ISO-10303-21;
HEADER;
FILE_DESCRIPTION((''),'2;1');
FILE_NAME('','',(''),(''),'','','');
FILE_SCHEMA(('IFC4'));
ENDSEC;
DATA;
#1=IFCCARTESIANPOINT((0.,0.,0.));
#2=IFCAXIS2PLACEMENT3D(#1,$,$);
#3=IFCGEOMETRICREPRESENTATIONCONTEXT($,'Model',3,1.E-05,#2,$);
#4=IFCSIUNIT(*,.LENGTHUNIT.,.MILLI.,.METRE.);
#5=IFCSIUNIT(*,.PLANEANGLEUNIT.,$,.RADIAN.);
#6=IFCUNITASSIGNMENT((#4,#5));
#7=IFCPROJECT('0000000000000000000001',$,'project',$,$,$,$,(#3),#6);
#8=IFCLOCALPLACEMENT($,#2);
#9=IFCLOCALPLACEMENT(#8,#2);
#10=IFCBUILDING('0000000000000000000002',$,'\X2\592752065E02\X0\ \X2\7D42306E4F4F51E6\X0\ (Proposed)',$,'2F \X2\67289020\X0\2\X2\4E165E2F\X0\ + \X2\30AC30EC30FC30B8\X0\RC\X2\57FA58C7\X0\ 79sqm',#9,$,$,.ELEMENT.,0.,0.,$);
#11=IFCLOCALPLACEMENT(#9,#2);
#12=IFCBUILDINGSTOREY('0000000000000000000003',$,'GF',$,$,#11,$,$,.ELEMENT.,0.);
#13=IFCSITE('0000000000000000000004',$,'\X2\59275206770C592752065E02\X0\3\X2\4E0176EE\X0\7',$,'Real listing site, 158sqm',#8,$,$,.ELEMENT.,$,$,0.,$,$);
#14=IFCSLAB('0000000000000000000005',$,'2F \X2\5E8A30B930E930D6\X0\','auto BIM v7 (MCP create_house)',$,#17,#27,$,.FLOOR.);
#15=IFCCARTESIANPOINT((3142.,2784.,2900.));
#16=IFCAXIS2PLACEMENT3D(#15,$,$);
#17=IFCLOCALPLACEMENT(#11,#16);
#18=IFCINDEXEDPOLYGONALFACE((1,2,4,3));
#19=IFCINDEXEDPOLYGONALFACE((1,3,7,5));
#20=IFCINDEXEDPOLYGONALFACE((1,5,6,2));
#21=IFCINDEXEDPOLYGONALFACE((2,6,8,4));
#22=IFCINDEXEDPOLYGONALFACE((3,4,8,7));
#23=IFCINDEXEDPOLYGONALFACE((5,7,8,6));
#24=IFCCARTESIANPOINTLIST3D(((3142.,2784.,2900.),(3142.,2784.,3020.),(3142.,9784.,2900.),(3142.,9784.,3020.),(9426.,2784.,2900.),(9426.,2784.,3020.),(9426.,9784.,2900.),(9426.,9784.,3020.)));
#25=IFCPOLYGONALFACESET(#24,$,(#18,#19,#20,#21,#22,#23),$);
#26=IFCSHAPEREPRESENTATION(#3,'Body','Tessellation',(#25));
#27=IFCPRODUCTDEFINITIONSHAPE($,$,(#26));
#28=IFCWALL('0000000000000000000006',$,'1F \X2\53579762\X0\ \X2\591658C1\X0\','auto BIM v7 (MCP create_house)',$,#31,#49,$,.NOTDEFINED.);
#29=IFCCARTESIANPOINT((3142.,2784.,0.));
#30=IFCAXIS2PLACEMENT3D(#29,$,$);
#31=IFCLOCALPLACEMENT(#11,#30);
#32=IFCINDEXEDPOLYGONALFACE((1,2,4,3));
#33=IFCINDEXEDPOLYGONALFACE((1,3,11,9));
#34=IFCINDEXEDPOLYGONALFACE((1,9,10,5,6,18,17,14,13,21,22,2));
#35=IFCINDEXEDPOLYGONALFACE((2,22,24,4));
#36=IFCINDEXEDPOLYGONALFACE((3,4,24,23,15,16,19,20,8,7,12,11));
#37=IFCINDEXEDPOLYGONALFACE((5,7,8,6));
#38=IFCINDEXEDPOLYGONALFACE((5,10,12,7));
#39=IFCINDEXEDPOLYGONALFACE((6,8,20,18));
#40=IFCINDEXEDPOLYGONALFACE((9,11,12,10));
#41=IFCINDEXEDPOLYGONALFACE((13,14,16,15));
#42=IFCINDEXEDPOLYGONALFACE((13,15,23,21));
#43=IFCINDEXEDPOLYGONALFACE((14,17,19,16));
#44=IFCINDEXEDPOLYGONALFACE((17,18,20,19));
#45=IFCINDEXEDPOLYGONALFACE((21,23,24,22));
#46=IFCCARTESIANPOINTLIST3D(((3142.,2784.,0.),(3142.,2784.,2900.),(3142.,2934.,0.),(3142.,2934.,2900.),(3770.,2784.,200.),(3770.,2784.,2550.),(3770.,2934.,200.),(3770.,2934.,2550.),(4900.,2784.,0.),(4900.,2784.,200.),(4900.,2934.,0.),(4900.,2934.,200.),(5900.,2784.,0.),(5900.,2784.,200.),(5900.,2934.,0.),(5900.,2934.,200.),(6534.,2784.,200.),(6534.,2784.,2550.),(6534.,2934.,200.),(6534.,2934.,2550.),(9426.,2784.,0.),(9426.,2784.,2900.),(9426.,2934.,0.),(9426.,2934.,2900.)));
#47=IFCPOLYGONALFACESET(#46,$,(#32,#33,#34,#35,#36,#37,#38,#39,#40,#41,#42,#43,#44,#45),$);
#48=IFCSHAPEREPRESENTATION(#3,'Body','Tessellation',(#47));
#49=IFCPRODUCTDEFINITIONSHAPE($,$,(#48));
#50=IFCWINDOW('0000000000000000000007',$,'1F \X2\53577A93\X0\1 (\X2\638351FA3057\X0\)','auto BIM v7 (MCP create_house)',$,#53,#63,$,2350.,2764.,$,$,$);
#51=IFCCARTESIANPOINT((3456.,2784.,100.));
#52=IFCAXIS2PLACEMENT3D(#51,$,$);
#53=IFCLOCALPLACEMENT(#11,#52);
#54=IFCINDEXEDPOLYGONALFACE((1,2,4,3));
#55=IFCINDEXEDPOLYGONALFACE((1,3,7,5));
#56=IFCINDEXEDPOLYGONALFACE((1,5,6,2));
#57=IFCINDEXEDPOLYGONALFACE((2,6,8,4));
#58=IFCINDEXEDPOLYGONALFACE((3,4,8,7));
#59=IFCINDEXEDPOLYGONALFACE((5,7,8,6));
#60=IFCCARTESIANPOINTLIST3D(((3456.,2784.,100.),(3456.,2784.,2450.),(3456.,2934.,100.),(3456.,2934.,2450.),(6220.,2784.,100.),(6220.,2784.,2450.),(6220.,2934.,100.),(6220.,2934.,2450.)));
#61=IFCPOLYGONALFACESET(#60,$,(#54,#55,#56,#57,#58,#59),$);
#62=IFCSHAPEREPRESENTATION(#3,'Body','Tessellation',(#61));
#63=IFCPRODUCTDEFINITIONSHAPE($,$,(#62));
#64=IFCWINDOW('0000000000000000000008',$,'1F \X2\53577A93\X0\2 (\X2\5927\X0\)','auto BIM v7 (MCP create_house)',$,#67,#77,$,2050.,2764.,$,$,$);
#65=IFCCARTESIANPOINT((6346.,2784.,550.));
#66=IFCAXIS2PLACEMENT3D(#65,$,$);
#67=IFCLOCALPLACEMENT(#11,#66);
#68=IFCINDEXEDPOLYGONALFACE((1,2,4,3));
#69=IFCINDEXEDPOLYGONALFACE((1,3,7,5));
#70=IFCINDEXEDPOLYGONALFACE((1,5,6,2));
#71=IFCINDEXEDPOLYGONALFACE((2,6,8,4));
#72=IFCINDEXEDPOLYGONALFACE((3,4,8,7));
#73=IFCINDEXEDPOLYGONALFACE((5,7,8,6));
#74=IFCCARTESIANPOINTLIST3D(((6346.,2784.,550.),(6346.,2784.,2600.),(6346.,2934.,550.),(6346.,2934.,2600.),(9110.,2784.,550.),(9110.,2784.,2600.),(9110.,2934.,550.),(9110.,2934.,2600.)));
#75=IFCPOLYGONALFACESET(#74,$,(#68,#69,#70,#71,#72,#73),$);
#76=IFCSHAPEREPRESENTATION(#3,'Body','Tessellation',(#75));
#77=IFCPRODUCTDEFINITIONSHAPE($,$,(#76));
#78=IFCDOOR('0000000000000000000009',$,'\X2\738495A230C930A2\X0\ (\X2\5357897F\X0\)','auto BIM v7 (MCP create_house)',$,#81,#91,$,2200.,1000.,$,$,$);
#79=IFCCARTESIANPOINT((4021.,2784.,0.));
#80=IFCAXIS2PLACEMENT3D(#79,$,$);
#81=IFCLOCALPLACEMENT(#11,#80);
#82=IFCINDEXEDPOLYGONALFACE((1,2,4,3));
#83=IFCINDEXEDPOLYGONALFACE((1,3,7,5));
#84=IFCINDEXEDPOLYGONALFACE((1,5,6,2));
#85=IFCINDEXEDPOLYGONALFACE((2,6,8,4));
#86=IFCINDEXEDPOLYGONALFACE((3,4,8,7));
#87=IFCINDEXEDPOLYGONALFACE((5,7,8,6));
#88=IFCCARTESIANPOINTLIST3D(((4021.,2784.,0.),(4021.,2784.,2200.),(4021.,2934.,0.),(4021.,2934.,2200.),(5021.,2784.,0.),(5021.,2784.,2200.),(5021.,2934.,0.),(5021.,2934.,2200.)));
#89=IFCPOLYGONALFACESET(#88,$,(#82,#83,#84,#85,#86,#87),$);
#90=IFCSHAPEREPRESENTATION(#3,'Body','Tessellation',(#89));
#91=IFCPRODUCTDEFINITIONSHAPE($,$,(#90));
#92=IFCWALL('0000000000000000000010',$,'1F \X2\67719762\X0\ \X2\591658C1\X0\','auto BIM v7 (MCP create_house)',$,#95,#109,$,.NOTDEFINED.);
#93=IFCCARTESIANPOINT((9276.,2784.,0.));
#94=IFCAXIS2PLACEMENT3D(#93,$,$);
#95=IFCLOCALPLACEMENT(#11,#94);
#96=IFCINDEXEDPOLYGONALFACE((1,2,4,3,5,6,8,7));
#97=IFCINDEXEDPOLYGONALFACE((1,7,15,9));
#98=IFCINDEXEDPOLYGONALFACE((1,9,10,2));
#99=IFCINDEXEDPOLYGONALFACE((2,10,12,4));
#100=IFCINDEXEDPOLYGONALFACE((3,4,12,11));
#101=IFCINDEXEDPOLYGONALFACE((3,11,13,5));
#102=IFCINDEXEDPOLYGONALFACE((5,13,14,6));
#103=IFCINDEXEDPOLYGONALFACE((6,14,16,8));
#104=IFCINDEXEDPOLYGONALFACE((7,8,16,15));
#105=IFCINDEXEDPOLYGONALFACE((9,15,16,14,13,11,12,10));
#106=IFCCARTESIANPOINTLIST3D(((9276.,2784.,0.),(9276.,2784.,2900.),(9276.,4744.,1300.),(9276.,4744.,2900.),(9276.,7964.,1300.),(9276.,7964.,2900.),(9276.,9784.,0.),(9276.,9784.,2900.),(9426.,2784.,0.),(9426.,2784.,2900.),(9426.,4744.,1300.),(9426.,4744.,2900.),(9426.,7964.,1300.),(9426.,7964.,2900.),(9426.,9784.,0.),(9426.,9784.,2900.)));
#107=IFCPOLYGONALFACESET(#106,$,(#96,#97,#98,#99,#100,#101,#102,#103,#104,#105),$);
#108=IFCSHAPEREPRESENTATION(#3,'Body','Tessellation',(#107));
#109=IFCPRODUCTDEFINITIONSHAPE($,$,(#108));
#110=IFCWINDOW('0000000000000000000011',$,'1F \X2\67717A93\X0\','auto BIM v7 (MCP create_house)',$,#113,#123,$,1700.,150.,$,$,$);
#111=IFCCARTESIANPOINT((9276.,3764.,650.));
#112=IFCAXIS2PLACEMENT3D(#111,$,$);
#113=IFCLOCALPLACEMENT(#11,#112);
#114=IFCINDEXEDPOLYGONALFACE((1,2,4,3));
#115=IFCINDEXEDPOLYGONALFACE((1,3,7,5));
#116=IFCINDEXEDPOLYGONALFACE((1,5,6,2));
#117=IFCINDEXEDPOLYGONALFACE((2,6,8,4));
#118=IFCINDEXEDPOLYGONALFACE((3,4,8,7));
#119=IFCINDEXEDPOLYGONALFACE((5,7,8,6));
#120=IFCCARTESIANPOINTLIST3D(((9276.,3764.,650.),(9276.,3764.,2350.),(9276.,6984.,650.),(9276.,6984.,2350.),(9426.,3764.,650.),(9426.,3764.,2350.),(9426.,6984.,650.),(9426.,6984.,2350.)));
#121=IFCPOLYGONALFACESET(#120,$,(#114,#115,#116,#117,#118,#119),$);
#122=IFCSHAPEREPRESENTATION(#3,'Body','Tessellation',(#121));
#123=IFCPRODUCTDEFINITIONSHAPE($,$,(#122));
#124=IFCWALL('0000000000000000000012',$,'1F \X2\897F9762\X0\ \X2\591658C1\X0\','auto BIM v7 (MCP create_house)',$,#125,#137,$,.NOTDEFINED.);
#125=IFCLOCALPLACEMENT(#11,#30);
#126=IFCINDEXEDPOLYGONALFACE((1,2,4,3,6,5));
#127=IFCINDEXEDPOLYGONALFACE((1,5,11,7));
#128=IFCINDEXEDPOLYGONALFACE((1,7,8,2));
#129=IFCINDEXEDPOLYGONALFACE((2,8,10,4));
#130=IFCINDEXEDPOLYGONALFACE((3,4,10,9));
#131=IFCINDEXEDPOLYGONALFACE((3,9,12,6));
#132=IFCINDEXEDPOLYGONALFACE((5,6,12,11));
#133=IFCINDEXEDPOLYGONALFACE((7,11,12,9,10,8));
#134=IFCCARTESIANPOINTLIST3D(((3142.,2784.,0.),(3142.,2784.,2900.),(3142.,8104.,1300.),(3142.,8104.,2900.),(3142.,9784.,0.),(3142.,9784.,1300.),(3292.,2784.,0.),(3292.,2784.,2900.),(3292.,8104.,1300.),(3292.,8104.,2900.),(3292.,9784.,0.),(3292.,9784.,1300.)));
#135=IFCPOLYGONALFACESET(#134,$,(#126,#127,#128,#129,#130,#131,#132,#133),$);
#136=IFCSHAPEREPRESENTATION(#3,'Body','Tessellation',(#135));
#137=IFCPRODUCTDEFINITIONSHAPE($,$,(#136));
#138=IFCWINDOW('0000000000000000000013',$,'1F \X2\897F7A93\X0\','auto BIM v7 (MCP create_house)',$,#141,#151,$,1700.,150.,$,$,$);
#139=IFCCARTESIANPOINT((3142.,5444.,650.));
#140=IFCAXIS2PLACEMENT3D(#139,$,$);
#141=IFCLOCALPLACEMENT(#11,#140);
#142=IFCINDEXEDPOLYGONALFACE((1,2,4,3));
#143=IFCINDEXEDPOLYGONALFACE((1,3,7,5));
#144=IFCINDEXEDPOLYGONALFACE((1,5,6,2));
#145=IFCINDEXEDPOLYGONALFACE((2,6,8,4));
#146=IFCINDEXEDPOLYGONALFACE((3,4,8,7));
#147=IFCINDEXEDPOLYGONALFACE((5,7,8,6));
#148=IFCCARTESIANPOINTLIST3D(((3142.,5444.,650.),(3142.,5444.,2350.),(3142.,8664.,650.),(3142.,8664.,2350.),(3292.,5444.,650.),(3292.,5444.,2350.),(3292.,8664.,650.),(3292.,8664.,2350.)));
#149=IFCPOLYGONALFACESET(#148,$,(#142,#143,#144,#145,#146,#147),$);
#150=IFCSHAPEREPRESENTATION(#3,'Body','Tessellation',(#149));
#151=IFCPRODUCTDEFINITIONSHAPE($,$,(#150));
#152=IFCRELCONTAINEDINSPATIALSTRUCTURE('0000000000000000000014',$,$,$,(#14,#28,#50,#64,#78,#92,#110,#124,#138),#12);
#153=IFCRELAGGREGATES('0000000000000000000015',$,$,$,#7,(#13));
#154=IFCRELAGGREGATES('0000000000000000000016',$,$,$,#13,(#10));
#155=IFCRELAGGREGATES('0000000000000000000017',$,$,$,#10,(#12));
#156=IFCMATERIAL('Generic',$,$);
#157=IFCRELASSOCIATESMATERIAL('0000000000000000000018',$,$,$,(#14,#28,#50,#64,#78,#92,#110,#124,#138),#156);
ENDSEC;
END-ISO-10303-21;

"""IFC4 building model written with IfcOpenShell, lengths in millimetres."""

from ifc_helpers import new_model, si_unit, frame, frame_2d, origin, place, context, project, spatial, rectangle, extrude, material, element, fill, save


model = new_model("IFC4")

# Units and contexts
model_context = context("Model", 3, precision=1e-05, world=origin())
ifc_project = project(units=[si_unit("LENGTHUNIT", "METRE", prefix="MILLI"), si_unit("PLANEANGLEUNIT", "RADIAN")], contexts=[model_context])

# Site, building, storey
site_placement = place(None, origin())
site = spatial("IfcSite", under=ifc_project, at=site_placement, Name="大分県大分市3丁目7", ObjectType="Real listing site, 158sqm", CompositionType="ELEMENT", RefElevation=0.0)
building_placement = place(site_placement, origin())
building = spatial("IfcBuilding", under=site, at=building_placement, Name="大分市 終の住処 (Proposed)", ObjectType="2F 木造2世帯 + ガレージRC基壇 79sqm", CompositionType="ELEMENT", ElevationOfRefHeight=0.0, ElevationOfTerrain=0.0)
storey_placement = place(building_placement, origin())
storey = spatial("IfcBuildingStorey", under=building, at=storey_placement, Name="GF", CompositionType="ELEMENT", Elevation=0.0)

# Slab
ifc_material = material(Name="Generic")
slab_1_placement = place(storey_placement, frame((3142.0, 2784.0, 2900.0)))
element("IfcSlab", 1, at=slab_1_placement, inside=storey, material=ifc_material, Name="2F 床スラブ", Description="auto BIM v7 (MCP create_house)", PredefinedType="FLOOR", context=model_context, shape_type="SweptSolid", body=[
    extrude(rectangle(XDim=6284.0, YDim=7000.0, at=frame_2d((3142.0, 3500.0))), frame((3142.0, 2784.0, 2900.0)), (0.0, 0.0, 1.0), 120.0),
])

# Wall, openings, windows, door
wall_1_placement = place(storey_placement, frame((3142.0, 2784.0, 0.0)))
wall_1 = element("IfcWall", 2, at=wall_1_placement, inside=storey, material=ifc_material, Name="1F 南面 外壁", Description="auto BIM v7 (MCP create_house)", PredefinedType="NOTDEFINED", context=model_context, shape_type="SweptSolid", body=[
    extrude(rectangle(XDim=6284.0, YDim=150.0, at=frame_2d((3142.0, 75.0))), frame((3142.0, 2784.0, 0.0)), (0.0, 0.0, 1.0), 2900.0),
])
opening_1_placement = place(storey_placement, frame((3456.0, 2784.0, 100.0)))
opening_1 = element("IfcOpeningElement", 3, at=opening_1_placement, cuts=wall_1, PredefinedType="NOTDEFINED", context=model_context, shape_type="SweptSolid", body=[
    extrude(rectangle(XDim=2764.0, YDim=150.0, at=frame_2d((1382.0, 75.0))), frame((3456.0, 2784.0, 100.0)), (0.0, 0.0, 1.0), 2350.0),
])
opening_2_placement = place(storey_placement, frame((6346.0, 2784.0, 550.0)))
opening_2 = element("IfcOpeningElement", 4, at=opening_2_placement, cuts=wall_1, PredefinedType="NOTDEFINED", context=model_context, shape_type="SweptSolid", body=[
    extrude(rectangle(XDim=2764.0, YDim=150.0, at=frame_2d((1382.0, 75.0))), frame((6346.0, 2784.0, 550.0)), (0.0, 0.0, 1.0), 2050.0),
])
opening_3_placement = place(storey_placement, frame((4021.0, 2784.0, 0.0)))
opening_3 = element("IfcOpeningElement", 5, at=opening_3_placement, cuts=wall_1, PredefinedType="NOTDEFINED", context=model_context, shape_type="SweptSolid", body=[
    extrude(rectangle(XDim=1000.0, YDim=150.0, at=frame_2d((500.0, 75.0))), frame((4021.0, 2784.0, 0.0)), (0.0, 0.0, 1.0), 2200.0),
])
window_1_placement = place(storey_placement, frame((3456.0, 2784.0, 100.0)))
window_1 = element("IfcWindow", 6, at=window_1_placement, inside=storey, material=ifc_material, Name="1F 南窓1 (掃出し)", Description="auto BIM v7 (MCP create_house)", OverallHeight=2350.0, OverallWidth=2764.0, context=model_context, shape_type="SweptSolid", body=[
    extrude(rectangle(XDim=2764.0, YDim=150.0, at=frame_2d((1382.0, 75.0))), frame((3456.0, 2784.0, 100.0)), (0.0, 0.0, 1.0), 2350.0),
])
fill(opening_1, window_1)
window_2_placement = place(storey_placement, frame((6346.0, 2784.0, 550.0)))
window_2 = element("IfcWindow", 7, at=window_2_placement, inside=storey, material=ifc_material, Name="1F 南窓2 (大)", Description="auto BIM v7 (MCP create_house)", OverallHeight=2050.0, OverallWidth=2764.0, context=model_context, shape_type="SweptSolid", body=[
    extrude(rectangle(XDim=2764.0, YDim=150.0, at=frame_2d((1382.0, 75.0))), frame((6346.0, 2784.0, 550.0)), (0.0, 0.0, 1.0), 2050.0),
])
fill(opening_2, window_2)
door_placement = place(storey_placement, frame((4021.0, 2784.0, 0.0)))
door = element("IfcDoor", 8, at=door_placement, inside=storey, material=ifc_material, Name="玄関ドア (南西)", Description="auto BIM v7 (MCP create_house)", OverallHeight=2200.0, OverallWidth=1000.0, context=model_context, shape_type="SweptSolid", body=[
    extrude(rectangle(XDim=1000.0, YDim=150.0, at=frame_2d((500.0, 75.0))), frame((4021.0, 2784.0, 0.0)), (0.0, 0.0, 1.0), 2200.0),
])
fill(opening_3, door)

# Walls, openings, windows
wall_2_placement = place(storey_placement, frame((9276.0, 2784.0, 0.0)))
wall_2 = element("IfcWall", 9, at=wall_2_placement, inside=storey, material=ifc_material, Name="1F 東面 外壁", Description="auto BIM v7 (MCP create_house)", PredefinedType="NOTDEFINED", context=model_context, shape_type="SweptSolid", body=[
    extrude(rectangle(XDim=150.0, YDim=7000.0, at=frame_2d((75.0, 3500.0))), frame((9276.0, 2784.0, 0.0)), (0.0, 0.0, 1.0), 2900.0),
])
opening_4_placement = place(storey_placement, frame((9276.0, 3764.0, 650.0)))
opening_4 = element("IfcOpeningElement", 10, at=opening_4_placement, cuts=wall_2, PredefinedType="NOTDEFINED", context=model_context, shape_type="SweptSolid", body=[
    extrude(rectangle(XDim=150.0, YDim=3220.0, at=frame_2d((75.0, 1610.0))), frame((9276.0, 3764.0, 650.0)), (0.0, 0.0, 1.0), 1700.0),
])
window_3_placement = place(storey_placement, frame((9276.0, 3764.0, 650.0)))
window_3 = element("IfcWindow", 11, at=window_3_placement, inside=storey, material=ifc_material, Name="1F 東窓", Description="auto BIM v7 (MCP create_house)", OverallHeight=1700.0, OverallWidth=150.0, context=model_context, shape_type="SweptSolid", body=[
    extrude(rectangle(XDim=150.0, YDim=3220.0, at=frame_2d((75.0, 1610.0))), frame((9276.0, 3764.0, 650.0)), (0.0, 0.0, 1.0), 1700.0),
])
fill(opening_4, window_3)
wall_3_placement = place(storey_placement, frame((3142.0, 2784.0, 0.0)))
wall_3 = element("IfcWall", 12, at=wall_3_placement, inside=storey, material=ifc_material, Name="1F 西面 外壁", Description="auto BIM v7 (MCP create_house)", PredefinedType="NOTDEFINED", context=model_context, shape_type="SweptSolid", body=[
    extrude(rectangle(XDim=150.0, YDim=7000.0, at=frame_2d((75.0, 3500.0))), frame((3142.0, 2784.0, 0.0)), (0.0, 0.0, 1.0), 2900.0),
])
opening_5_placement = place(storey_placement, frame((3142.0, 5444.0, 650.0)))
opening_5 = element("IfcOpeningElement", 13, at=opening_5_placement, cuts=wall_3, PredefinedType="NOTDEFINED", context=model_context, shape_type="SweptSolid", body=[
    extrude(rectangle(XDim=150.0, YDim=3220.0, at=frame_2d((75.0, 1610.0))), frame((3142.0, 5444.0, 650.0)), (0.0, 0.0, 1.0), 1700.0),
])
window_4_placement = place(storey_placement, frame((3142.0, 5444.0, 650.0)))
window_4 = element("IfcWindow", 14, at=window_4_placement, inside=storey, material=ifc_material, Name="1F 西窓", Description="auto BIM v7 (MCP create_house)", OverallHeight=1700.0, OverallWidth=150.0, context=model_context, shape_type="SweptSolid", body=[
    extrude(rectangle(XDim=150.0, YDim=3220.0, at=frame_2d((75.0, 1610.0))), frame((3142.0, 5444.0, 650.0)), (0.0, 0.0, 1.0), 1700.0),
])
fill(opening_5, window_4)

save(model, "model.ifc")
